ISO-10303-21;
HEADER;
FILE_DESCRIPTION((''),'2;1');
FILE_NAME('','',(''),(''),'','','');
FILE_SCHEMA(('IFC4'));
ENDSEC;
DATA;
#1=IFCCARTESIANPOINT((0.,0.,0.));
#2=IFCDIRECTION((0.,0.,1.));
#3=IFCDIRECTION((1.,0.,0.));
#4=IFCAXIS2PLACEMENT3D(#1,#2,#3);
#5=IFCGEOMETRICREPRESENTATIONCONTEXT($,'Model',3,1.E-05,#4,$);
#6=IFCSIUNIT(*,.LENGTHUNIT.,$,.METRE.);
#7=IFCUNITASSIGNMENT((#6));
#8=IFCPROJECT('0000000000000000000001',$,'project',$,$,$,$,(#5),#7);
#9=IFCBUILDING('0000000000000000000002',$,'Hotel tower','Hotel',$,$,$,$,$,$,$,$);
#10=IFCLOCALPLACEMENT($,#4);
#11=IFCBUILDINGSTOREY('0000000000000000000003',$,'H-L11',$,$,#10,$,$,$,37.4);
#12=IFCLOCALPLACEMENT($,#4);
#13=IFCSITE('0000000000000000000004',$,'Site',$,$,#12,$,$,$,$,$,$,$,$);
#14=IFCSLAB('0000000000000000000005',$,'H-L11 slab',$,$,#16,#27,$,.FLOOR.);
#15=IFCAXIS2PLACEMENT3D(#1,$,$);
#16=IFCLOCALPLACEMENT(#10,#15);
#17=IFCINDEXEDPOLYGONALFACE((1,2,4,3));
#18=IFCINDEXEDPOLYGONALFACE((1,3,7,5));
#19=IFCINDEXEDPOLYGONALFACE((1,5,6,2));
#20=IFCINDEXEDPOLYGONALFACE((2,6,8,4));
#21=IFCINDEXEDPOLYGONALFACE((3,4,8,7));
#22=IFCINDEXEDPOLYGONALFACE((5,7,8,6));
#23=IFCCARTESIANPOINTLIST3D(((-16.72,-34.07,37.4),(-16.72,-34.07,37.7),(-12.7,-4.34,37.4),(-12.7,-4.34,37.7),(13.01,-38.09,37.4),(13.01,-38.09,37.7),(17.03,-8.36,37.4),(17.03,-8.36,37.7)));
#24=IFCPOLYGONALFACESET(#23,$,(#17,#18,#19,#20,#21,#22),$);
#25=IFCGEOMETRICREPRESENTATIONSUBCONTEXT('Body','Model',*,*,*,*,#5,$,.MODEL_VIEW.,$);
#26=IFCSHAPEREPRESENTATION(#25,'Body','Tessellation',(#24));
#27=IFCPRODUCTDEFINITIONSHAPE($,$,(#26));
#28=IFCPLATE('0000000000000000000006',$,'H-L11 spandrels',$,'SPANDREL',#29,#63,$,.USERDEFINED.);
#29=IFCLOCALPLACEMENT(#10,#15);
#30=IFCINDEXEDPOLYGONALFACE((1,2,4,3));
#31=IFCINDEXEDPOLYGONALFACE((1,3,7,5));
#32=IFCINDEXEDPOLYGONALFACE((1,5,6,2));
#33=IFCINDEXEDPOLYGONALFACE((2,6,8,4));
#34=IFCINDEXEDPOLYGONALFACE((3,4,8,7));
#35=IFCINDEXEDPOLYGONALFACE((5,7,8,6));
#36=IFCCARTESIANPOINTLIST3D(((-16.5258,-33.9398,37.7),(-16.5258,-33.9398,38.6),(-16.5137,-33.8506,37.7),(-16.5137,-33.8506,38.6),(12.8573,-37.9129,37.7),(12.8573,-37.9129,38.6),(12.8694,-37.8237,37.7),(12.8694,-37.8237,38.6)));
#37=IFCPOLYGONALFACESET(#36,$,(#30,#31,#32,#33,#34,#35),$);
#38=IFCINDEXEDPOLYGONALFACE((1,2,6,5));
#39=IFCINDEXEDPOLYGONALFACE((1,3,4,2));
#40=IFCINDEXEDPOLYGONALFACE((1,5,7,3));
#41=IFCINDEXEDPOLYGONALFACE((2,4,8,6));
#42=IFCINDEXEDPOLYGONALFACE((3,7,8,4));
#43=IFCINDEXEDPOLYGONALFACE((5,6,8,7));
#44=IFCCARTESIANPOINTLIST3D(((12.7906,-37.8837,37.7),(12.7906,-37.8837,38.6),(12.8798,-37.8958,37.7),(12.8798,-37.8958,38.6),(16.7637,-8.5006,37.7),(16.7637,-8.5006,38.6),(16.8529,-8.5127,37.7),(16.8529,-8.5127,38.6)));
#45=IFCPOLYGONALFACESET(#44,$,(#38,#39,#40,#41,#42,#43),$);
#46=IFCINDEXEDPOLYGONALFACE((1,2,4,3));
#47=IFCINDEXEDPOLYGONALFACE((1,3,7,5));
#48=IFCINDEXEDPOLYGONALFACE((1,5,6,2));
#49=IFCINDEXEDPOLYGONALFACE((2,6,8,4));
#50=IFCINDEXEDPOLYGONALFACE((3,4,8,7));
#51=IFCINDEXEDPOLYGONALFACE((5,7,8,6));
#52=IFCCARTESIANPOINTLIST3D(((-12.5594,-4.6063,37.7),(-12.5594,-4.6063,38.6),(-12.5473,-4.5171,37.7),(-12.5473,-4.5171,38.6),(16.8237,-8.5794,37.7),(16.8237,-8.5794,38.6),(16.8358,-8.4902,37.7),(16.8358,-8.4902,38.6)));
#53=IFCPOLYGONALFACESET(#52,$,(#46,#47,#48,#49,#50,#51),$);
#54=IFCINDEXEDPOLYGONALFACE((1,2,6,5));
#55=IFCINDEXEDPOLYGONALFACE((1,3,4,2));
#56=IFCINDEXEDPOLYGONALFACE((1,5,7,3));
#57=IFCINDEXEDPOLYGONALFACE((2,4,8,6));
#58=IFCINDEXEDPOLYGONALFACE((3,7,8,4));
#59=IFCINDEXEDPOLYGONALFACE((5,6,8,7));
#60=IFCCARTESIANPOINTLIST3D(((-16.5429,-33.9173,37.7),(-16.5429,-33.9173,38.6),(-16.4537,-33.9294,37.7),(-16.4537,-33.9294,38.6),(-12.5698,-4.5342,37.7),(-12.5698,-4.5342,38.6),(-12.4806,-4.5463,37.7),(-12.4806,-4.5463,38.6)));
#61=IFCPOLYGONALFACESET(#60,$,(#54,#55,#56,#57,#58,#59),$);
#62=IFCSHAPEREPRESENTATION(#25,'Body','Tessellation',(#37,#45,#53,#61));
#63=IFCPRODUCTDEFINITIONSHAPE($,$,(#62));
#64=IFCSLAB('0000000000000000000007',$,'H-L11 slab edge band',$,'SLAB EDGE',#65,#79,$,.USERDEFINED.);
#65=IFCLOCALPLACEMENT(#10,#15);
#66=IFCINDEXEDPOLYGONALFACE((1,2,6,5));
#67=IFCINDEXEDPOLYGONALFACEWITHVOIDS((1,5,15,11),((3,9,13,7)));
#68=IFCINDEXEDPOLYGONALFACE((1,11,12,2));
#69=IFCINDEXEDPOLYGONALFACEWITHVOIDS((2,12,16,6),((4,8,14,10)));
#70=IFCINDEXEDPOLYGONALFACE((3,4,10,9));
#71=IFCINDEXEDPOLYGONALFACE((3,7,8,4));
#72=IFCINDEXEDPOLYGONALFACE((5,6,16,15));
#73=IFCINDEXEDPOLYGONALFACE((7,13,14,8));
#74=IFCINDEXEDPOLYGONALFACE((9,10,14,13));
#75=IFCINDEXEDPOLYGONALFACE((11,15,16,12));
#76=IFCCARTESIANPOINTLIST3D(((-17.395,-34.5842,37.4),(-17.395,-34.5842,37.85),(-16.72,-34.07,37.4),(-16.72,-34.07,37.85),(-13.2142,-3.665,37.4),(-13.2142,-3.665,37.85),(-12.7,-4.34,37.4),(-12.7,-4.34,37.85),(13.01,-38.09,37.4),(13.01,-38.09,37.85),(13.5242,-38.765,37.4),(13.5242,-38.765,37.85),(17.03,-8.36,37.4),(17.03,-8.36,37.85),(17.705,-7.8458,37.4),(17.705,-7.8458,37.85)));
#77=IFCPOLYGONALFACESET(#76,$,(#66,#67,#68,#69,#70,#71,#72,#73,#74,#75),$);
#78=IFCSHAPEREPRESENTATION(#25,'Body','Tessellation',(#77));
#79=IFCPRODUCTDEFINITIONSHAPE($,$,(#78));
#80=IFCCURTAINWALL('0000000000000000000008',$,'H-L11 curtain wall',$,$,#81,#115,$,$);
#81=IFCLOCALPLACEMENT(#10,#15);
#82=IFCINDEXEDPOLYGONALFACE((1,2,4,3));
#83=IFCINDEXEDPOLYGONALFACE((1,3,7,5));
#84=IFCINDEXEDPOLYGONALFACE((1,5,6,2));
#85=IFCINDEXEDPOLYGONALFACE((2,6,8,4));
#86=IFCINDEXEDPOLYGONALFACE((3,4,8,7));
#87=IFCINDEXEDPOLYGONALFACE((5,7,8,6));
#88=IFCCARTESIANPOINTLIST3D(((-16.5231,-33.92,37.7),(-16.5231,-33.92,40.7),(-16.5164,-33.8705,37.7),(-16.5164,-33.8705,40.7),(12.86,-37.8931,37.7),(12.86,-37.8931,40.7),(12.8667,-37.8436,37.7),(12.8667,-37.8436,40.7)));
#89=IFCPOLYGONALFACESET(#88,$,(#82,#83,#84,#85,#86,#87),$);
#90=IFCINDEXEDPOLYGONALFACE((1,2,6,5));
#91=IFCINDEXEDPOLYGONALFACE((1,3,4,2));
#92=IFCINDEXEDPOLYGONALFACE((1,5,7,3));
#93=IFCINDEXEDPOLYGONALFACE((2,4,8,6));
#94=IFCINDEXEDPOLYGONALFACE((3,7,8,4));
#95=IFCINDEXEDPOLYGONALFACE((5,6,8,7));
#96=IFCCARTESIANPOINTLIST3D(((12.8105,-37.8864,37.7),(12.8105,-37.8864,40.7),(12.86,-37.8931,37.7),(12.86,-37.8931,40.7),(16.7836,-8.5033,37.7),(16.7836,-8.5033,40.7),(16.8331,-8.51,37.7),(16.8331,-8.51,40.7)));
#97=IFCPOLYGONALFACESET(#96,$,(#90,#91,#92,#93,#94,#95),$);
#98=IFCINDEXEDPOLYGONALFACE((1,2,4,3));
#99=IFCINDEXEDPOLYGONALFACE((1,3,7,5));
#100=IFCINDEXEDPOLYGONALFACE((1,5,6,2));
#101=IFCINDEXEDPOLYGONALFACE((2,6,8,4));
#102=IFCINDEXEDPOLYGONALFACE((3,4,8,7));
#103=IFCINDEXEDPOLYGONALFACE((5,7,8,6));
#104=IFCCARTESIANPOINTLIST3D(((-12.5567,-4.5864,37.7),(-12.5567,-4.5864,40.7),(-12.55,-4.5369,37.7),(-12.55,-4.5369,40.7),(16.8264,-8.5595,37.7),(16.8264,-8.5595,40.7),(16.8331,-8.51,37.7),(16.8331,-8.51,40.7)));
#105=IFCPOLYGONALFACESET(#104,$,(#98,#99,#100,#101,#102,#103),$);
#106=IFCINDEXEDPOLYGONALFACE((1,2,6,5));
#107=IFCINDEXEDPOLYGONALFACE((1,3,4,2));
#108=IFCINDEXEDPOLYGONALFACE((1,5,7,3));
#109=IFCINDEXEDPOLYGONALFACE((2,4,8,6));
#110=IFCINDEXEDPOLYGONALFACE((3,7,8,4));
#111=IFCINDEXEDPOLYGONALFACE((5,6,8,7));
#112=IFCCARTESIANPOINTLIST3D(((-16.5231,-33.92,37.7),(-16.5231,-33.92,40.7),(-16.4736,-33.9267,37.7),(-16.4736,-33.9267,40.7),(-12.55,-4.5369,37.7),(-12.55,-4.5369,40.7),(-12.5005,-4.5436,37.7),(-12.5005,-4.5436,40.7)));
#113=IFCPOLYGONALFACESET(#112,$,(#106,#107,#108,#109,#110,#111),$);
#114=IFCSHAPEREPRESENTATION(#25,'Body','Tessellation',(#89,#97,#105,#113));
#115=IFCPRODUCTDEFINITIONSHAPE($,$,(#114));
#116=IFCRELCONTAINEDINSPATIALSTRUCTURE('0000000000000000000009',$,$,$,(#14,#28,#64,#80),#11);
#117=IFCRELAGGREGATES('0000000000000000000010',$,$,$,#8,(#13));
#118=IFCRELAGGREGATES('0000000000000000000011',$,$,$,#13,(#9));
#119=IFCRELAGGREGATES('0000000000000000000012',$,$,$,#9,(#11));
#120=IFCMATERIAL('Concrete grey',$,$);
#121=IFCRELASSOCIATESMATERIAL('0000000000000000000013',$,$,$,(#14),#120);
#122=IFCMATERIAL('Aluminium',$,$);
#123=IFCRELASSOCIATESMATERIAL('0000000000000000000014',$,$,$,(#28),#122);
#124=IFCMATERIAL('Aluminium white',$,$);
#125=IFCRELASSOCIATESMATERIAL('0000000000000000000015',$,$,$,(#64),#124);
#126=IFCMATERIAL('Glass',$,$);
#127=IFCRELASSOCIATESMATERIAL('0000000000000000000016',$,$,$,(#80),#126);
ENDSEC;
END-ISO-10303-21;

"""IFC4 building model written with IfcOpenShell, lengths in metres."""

from ifc_helpers import new_model, si_unit, frame, origin_with_axes, place, context, subcontext, project, spatial, polyline, outline, extrude, material, element, save


model = new_model("IFC4")

# Units and contexts
model_context = context("Model", 3, precision=1e-05, world=origin_with_axes())
body_context = subcontext(model_context, "Body", "Model", "MODEL_VIEW")
ifc_project = project(units=[si_unit("LENGTHUNIT", "METRE")], contexts=[model_context])

# Site, building, storey
site_placement = place(None, origin_with_axes())
site = spatial("IfcSite", under=ifc_project, at=site_placement, Name="Site")
building = spatial("IfcBuilding", under=site, Name="Hotel tower", Description="Hotel")
storey_placement = place(None, origin_with_axes())
storey = spatial("IfcBuildingStorey", under=building, at=storey_placement, Name="H-L11", Elevation=37.4)

# Shared definitions
ifc_material_1 = material(Name="Aluminium")

# Slab
ifc_material_2 = material(Name="Concrete grey")
slab_1_placement = place(storey_placement, origin_with_axes())
element("IfcSlab", 1, at=slab_1_placement, inside=storey, material=ifc_material_2, Name="H-L11 slab", PredefinedType="FLOOR", context=body_context, shape_type="SweptSolid", body=[
    extrude(outline(polyline([(-16.72, -34.07), (13.01, -38.09), (17.03, -8.36), (-12.7, -4.34), (-16.72, -34.07)])), frame((0.0, 0.0, 37.4), z_axis=(0.0, 0.0, 1.0), x_axis=(1.0, 0.0, 0.0)), (0.0, 0.0, 1.0), 0.3),
])

# Plate
plate_placement = place(storey_placement, origin_with_axes())
element("IfcPlate", 2, at=plate_placement, inside=storey, material=ifc_material_1, Name="H-L11 spandrels", ObjectType="SPANDREL", PredefinedType="USERDEFINED", context=body_context, shape_type="SweptSolid", body=[
    extrude(outline(polyline([(-16.5258, -33.9398), (12.8573, -37.9129), (12.8694, -37.8237), (-16.5137, -33.8506), (-16.5258, -33.9398)])), frame((0.0, 0.0, 37.7), z_axis=(0.0, 0.0, 1.0), x_axis=(1.0, 0.0, 0.0)), (0.0, 0.0, 1.0), 0.9),
    extrude(outline(polyline([(12.8798, -37.8958), (16.8529, -8.5127), (16.7637, -8.5006), (12.7906, -37.8837), (12.8798, -37.8958)])), frame((0.0, 0.0, 37.7), z_axis=(0.0, 0.0, 1.0), x_axis=(1.0, 0.0, 0.0)), (0.0, 0.0, 1.0), 0.9),
    extrude(outline(polyline([(16.8358, -8.4902), (-12.5473, -4.5171), (-12.5594, -4.6063), (16.8237, -8.5794), (16.8358, -8.4902)])), frame((0.0, 0.0, 37.7), z_axis=(0.0, 0.0, 1.0), x_axis=(1.0, 0.0, 0.0)), (0.0, 0.0, 1.0), 0.9),
    extrude(outline(polyline([(-12.5698, -4.5342), (-16.5429, -33.9173), (-16.4537, -33.9294), (-12.4806, -4.5463), (-12.5698, -4.5342)])), frame((0.0, 0.0, 37.7), z_axis=(0.0, 0.0, 1.0), x_axis=(1.0, 0.0, 0.0)), (0.0, 0.0, 1.0), 0.9),
])

# Slab
ifc_material_3 = material(Name="Aluminium white")
slab_2_placement = place(storey_placement, origin_with_axes())
element("IfcSlab", 3, at=slab_2_placement, inside=storey, material=ifc_material_3, Name="H-L11 slab edge band", ObjectType="SLAB EDGE", PredefinedType="USERDEFINED", context=body_context, shape_type="SweptSolid", body=[
    extrude(outline(polyline([(-17.395, -34.5842), (13.5242, -38.765), (17.705, -7.8458), (-13.2142, -3.665), (-17.395, -34.5842)]), holes=[polyline([(-16.72, -34.07), (13.01, -38.09), (17.03, -8.36), (-12.7, -4.34), (-16.72, -34.07)])]), frame((0.0, 0.0, 37.4), z_axis=(0.0, 0.0, 1.0), x_axis=(1.0, 0.0, 0.0)), (0.0, 0.0, 1.0), 0.45),
])

# Curtain wall
ifc_material_4 = material(Name="Glass")
curtain_wall_placement = place(storey_placement, origin_with_axes())
element("IfcCurtainWall", 4, at=curtain_wall_placement, inside=storey, material=ifc_material_4, Name="H-L11 curtain wall", context=body_context, shape_type="SweptSolid", body=[
    extrude(outline(polyline([(-16.5231, -33.92), (12.86, -37.8931), (12.8667, -37.8436), (-16.5164, -33.8705), (-16.5231, -33.92)])), frame((0.0, 0.0, 37.7), z_axis=(0.0, 0.0, 1.0), x_axis=(1.0, 0.0, 0.0)), (0.0, 0.0, 1.0), 3.0),
    extrude(outline(polyline([(12.86, -37.8931), (16.8331, -8.51), (16.7836, -8.5033), (12.8105, -37.8864), (12.86, -37.8931)])), frame((0.0, 0.0, 37.7), z_axis=(0.0, 0.0, 1.0), x_axis=(1.0, 0.0, 0.0)), (0.0, 0.0, 1.0), 3.0),
    extrude(outline(polyline([(16.8331, -8.51), (-12.55, -4.5369), (-12.5567, -4.5864), (16.8264, -8.5595), (16.8331, -8.51)])), frame((0.0, 0.0, 37.7), z_axis=(0.0, 0.0, 1.0), x_axis=(1.0, 0.0, 0.0)), (0.0, 0.0, 1.0), 3.0),
    extrude(outline(polyline([(-12.55, -4.5369), (-16.5231, -33.92), (-16.4736, -33.9267), (-12.5005, -4.5436), (-12.55, -4.5369)])), frame((0.0, 0.0, 37.7), z_axis=(0.0, 0.0, 1.0), x_axis=(1.0, 0.0, 0.0)), (0.0, 0.0, 1.0), 3.0),
])

save(model, "model.ifc")
